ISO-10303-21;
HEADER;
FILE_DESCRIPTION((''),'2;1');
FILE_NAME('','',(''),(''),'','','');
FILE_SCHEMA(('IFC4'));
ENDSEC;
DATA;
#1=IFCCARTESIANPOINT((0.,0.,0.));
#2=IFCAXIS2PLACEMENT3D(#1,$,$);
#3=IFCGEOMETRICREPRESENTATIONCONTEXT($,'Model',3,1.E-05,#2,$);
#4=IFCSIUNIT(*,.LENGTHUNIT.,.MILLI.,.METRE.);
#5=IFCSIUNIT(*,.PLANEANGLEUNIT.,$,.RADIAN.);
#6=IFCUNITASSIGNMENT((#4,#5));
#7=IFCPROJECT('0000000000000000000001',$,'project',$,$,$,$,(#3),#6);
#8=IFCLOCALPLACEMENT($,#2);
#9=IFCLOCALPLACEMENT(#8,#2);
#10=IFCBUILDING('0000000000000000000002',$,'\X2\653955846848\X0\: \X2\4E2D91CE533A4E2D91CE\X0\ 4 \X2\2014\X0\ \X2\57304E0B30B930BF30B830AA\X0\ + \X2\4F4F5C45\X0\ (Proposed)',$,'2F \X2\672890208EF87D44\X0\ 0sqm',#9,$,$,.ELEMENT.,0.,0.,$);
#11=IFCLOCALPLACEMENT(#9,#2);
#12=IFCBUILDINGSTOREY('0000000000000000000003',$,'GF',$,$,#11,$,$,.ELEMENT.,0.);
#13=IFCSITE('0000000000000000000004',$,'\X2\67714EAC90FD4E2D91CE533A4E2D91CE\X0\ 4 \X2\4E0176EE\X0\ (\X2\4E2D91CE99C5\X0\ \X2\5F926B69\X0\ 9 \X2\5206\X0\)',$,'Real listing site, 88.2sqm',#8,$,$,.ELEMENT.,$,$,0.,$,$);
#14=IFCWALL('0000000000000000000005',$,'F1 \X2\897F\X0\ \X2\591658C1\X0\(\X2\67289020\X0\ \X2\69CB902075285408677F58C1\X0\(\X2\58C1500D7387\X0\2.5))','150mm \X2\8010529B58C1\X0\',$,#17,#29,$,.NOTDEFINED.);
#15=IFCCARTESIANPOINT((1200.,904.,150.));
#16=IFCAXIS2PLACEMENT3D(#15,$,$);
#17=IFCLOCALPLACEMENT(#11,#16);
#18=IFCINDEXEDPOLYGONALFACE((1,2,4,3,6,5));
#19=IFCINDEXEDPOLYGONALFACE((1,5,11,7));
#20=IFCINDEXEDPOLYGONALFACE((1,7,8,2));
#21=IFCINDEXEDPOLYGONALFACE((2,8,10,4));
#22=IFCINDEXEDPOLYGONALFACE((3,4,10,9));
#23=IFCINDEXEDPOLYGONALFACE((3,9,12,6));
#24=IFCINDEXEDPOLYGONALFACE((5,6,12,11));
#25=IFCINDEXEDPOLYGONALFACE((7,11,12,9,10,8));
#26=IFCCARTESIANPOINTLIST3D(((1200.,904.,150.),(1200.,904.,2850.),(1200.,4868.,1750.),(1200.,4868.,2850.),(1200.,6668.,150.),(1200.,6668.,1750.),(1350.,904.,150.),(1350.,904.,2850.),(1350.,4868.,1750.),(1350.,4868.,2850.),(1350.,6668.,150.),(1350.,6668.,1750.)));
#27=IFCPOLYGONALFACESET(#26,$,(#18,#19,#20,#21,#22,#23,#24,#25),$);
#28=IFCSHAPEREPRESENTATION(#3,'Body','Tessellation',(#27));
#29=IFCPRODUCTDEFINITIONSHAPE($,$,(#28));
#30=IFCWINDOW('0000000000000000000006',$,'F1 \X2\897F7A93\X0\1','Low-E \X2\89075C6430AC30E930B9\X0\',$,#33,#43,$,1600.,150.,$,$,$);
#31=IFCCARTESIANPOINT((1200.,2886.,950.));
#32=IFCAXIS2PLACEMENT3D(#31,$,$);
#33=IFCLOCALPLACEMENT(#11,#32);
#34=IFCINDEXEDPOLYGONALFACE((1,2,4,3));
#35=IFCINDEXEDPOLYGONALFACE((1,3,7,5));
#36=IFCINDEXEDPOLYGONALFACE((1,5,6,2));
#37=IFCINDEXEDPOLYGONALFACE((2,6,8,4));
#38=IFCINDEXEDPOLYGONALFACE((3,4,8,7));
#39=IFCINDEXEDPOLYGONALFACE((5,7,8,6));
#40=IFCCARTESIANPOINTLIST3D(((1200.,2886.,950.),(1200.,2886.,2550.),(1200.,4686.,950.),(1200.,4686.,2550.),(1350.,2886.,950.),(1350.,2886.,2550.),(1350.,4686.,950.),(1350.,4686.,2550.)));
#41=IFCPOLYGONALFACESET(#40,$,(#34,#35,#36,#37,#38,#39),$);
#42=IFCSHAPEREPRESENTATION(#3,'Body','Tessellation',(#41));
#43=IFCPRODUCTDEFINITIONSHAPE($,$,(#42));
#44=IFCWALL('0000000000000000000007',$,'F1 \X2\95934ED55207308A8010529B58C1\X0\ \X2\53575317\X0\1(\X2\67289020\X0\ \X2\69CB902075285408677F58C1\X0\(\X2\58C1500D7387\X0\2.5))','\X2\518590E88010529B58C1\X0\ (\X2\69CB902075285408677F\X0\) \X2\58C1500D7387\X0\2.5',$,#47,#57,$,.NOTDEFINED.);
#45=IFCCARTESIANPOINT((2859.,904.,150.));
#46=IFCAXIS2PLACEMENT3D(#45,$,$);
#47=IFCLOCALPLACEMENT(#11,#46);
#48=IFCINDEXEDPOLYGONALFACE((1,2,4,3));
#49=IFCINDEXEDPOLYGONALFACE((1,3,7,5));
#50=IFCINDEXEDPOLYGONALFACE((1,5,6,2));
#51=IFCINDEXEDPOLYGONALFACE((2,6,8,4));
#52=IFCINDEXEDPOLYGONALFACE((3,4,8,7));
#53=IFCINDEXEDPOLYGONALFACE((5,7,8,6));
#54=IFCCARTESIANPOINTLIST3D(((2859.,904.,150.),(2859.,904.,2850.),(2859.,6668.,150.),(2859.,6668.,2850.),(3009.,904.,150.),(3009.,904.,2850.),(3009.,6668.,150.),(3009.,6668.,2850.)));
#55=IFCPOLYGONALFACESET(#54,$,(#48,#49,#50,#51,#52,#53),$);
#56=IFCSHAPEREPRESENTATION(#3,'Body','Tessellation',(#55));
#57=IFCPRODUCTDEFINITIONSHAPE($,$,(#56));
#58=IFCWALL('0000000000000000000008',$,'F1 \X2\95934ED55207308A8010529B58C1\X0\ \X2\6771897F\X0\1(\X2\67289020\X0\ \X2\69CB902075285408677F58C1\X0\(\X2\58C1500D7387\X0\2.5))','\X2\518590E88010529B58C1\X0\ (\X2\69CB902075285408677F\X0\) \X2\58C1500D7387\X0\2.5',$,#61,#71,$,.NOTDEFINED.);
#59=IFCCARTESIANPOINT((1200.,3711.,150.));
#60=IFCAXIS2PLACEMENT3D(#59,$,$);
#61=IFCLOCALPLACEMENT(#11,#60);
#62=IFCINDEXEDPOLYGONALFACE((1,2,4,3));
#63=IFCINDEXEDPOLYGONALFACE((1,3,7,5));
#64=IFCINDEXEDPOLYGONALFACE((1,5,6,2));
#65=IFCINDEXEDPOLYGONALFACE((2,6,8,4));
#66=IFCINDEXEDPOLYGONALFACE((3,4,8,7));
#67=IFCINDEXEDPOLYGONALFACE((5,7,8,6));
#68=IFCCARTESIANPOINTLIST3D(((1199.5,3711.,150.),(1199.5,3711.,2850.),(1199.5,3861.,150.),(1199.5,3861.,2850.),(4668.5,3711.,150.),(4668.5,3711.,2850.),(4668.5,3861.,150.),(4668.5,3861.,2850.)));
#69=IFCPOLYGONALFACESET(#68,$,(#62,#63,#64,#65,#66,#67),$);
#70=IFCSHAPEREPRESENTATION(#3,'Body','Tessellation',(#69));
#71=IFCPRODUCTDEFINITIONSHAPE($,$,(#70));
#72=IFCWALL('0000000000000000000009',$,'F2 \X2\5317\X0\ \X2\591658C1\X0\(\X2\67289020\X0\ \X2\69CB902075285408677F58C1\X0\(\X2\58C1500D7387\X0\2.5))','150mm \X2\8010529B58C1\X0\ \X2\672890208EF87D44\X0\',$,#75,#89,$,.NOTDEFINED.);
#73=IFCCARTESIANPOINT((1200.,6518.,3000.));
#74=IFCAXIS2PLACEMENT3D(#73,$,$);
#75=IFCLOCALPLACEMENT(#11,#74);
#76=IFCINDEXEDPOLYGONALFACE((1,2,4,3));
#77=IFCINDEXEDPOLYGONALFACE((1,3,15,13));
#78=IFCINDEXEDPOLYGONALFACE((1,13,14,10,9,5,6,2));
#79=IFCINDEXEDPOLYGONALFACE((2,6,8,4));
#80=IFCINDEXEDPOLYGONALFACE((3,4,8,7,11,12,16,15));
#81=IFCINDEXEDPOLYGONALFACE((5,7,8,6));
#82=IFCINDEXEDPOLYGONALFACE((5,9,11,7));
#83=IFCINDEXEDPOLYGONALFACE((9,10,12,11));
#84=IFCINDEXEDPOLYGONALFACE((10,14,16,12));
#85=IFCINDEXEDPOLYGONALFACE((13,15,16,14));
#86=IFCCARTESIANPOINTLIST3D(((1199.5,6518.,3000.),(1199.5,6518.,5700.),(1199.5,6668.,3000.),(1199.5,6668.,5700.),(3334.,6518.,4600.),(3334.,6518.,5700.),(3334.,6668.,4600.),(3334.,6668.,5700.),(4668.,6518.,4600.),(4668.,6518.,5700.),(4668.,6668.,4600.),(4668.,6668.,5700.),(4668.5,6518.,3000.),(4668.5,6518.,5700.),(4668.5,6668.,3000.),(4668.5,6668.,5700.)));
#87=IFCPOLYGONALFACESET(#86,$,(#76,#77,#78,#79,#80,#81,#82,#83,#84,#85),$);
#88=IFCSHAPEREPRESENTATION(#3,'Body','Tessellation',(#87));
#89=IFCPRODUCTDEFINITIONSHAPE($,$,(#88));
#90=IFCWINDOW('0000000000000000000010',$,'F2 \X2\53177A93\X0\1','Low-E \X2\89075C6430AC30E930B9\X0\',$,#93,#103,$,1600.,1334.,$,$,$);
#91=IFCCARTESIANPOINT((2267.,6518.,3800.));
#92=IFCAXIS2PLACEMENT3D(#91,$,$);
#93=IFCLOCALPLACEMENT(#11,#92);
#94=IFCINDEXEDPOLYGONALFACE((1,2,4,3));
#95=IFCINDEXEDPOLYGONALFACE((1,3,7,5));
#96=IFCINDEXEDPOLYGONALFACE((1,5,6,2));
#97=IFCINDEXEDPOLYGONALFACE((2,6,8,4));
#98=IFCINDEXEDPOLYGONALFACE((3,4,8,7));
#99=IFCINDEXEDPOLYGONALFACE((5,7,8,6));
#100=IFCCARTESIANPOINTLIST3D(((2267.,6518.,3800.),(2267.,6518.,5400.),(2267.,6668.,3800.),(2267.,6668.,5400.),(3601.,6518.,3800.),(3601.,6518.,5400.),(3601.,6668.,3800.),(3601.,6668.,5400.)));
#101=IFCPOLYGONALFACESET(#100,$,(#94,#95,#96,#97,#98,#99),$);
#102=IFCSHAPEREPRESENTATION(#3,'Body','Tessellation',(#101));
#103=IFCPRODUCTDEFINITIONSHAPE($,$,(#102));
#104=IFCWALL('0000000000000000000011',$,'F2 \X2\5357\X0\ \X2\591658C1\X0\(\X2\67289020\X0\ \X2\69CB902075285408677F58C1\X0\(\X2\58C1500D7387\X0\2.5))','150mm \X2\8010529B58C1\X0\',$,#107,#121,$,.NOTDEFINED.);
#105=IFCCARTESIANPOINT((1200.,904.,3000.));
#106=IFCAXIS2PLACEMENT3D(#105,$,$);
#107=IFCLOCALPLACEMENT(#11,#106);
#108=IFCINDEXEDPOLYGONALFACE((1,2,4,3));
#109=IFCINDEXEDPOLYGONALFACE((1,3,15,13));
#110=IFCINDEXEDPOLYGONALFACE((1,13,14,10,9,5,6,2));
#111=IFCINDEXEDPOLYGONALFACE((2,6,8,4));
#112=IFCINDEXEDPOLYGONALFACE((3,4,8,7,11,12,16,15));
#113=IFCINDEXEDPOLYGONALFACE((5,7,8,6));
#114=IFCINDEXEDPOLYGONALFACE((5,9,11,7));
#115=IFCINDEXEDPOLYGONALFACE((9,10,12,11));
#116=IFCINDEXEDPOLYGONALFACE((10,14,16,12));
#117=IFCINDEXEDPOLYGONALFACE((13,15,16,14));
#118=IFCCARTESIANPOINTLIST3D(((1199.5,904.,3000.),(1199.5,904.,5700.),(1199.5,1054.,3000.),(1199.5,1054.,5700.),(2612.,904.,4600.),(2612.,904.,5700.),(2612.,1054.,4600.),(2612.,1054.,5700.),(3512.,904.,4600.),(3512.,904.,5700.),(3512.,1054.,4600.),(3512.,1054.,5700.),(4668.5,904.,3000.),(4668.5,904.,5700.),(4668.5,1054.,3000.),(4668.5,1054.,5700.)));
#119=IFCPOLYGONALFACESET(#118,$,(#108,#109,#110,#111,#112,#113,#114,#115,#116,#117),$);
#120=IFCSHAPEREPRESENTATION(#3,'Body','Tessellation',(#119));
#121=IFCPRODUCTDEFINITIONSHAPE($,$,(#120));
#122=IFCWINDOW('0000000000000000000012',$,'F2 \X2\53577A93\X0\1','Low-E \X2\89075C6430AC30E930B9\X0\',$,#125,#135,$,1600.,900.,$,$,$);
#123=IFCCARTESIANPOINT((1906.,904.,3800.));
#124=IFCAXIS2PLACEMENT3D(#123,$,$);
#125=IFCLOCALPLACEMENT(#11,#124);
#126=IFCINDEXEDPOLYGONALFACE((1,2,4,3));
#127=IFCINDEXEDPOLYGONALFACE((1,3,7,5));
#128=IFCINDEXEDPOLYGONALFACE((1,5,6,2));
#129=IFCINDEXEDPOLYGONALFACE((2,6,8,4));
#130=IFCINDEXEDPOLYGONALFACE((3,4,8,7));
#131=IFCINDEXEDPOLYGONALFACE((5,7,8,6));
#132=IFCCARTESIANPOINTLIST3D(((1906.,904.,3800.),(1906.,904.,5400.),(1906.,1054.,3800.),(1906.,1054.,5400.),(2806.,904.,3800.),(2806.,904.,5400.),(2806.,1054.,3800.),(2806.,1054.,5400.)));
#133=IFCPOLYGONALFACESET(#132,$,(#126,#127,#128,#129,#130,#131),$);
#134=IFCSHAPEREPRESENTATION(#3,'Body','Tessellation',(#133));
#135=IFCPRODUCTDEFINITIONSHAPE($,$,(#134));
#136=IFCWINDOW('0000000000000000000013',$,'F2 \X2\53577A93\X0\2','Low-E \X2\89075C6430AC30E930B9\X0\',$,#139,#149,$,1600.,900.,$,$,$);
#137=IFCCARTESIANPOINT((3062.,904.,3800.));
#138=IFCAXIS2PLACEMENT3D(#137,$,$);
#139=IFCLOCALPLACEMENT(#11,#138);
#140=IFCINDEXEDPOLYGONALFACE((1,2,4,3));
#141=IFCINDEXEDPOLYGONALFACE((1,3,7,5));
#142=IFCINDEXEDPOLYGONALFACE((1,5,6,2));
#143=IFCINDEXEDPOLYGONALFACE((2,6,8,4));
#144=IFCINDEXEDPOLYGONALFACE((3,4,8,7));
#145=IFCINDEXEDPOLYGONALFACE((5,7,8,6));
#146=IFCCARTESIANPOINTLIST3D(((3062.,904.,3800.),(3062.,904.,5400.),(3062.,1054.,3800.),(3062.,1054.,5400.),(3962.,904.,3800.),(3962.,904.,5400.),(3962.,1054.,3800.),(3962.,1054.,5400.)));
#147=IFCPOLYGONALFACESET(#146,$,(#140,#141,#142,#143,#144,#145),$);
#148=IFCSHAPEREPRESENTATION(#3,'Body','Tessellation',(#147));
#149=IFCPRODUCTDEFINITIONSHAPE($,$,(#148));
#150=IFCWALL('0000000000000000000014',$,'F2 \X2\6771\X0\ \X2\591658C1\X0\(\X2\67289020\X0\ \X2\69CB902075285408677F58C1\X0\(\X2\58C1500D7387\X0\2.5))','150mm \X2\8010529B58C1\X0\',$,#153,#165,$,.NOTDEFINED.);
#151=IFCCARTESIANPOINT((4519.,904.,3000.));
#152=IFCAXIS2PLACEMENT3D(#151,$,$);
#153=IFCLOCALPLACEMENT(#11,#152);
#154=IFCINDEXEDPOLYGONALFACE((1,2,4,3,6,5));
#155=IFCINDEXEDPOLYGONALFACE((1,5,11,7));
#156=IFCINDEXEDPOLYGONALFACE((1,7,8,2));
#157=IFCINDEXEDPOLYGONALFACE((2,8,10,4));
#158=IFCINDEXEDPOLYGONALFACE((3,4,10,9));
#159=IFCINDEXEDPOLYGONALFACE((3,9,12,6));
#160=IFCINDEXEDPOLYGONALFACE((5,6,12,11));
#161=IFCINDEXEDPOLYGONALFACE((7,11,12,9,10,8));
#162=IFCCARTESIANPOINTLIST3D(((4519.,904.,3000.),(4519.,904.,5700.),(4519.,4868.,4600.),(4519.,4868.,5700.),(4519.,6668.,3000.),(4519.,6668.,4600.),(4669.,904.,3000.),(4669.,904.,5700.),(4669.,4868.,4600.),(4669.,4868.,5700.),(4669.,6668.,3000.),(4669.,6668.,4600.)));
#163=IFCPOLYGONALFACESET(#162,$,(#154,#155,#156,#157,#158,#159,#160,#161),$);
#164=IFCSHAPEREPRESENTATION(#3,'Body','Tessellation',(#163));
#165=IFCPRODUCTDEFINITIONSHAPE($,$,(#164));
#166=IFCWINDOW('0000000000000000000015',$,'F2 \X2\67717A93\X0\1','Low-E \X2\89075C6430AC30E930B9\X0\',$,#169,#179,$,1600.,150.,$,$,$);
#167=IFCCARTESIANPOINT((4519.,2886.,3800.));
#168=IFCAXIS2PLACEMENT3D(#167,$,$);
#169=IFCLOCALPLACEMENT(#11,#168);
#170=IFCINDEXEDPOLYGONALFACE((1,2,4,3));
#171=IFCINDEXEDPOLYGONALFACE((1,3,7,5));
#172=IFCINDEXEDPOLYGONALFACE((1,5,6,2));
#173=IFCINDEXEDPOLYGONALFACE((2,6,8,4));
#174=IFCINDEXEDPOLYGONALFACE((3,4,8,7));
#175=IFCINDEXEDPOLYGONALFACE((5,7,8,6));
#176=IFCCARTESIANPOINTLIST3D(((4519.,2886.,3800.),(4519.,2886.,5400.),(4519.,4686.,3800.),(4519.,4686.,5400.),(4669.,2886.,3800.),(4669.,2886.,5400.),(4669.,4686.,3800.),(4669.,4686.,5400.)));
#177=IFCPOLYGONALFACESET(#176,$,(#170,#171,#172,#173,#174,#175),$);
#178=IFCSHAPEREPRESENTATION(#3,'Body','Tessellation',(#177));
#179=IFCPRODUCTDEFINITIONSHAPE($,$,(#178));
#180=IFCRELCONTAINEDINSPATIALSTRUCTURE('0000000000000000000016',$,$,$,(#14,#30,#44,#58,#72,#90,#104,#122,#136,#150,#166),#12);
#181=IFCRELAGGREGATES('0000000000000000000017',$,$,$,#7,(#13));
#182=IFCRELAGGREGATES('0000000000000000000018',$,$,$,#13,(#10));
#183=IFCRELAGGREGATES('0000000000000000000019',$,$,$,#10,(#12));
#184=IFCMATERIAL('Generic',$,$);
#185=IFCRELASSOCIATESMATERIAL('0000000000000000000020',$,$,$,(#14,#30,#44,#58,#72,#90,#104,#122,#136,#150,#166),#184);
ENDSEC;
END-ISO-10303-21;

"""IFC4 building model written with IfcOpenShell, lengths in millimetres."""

from ifc_helpers import new_model, si_unit, frame, frame_2d, origin, place, context, project, spatial, rectangle, extrude, material, element, fill, save


model = new_model("IFC4")

# Units and contexts
model_context = context("Model", 3, precision=1e-05, world=origin())
ifc_project = project(units=[si_unit("LENGTHUNIT", "METRE", prefix="MILLI"), si_unit("PLANEANGLEUNIT", "RADIAN")], contexts=[model_context])

# Site, building, storey
site_placement = place(None, origin())
site = spatial("IfcSite", under=ifc_project, at=site_placement, Name="東京都中野区中野 4 丁目 (中野駅 徒歩 9 分)", ObjectType="Real listing site, 88.2sqm", CompositionType="ELEMENT", RefElevation=0.0)
building_placement = place(site_placement, origin())
building = spatial("IfcBuilding", under=site, at=building_placement, Name="改善案: 中野区中野 4 — 地下スタジオ + 住居 (Proposed)", ObjectType="2F 木造軸組 0sqm", CompositionType="ELEMENT", ElevationOfRefHeight=0.0, ElevationOfTerrain=0.0)
storey_placement = place(building_placement, origin())
storey = spatial("IfcBuildingStorey", under=building, at=storey_placement, Name="GF", CompositionType="ELEMENT", Elevation=0.0)

# Shared definitions
ifc_material_1 = material(Name="Generic")

# Wall, opening, window
wall_1_placement = place(storey_placement, frame((1200.0, 904.0, 150.0)))
wall_1 = element("IfcWall", 1, at=wall_1_placement, inside=storey, material=ifc_material_1, Name="F1 西 外壁(木造 構造用合板壁(壁倍率2.5))", Description="150mm 耐力壁", PredefinedType="NOTDEFINED", context=model_context, shape_type="SweptSolid", body=[
    extrude(rectangle(XDim=150.0, YDim=5764.0, at=frame_2d((75.0, 2882.0))), frame((1200.0, 904.0, 150.0)), (0.0, 0.0, 1.0), 2700.0),
])
opening_1_placement = place(storey_placement, frame((1200.0, 2886.0, 950.0)))
opening_1 = element("IfcOpeningElement", 2, at=opening_1_placement, cuts=wall_1, PredefinedType="NOTDEFINED", context=model_context, shape_type="SweptSolid", body=[
    extrude(rectangle(XDim=150.0, YDim=1800.0, at=frame_2d((75.0, 900.0))), frame((1200.0, 2886.0, 950.0)), (0.0, 0.0, 1.0), 1600.0),
])
window_1_placement = place(storey_placement, frame((1200.0, 2886.0, 950.0)))
window_1 = element("IfcWindow", 3, at=window_1_placement, inside=storey, material=ifc_material_1, Name="F1 西窓1", Description="Low-E 複層ガラス", OverallHeight=1600.0, OverallWidth=150.0, context=model_context, shape_type="SweptSolid", body=[
    extrude(rectangle(XDim=150.0, YDim=1800.0, at=frame_2d((75.0, 900.0))), frame((1200.0, 2886.0, 950.0)), (0.0, 0.0, 1.0), 1600.0),
])
fill(opening_1, window_1)

# Walls
wall_2_placement = place(storey_placement, frame((2859.0, 904.0, 150.0)))
element("IfcWall", 4, at=wall_2_placement, inside=storey, material=ifc_material_1, Name="F1 間仕切り耐力壁 南北1(木造 構造用合板壁(壁倍率2.5))", Description="内部耐力壁 (構造用合板) 壁倍率2.5", PredefinedType="NOTDEFINED", context=model_context, shape_type="SweptSolid", body=[
    extrude(rectangle(XDim=150.0, YDim=5764.0, at=frame_2d((75.0, 2882.0))), frame((2859.0, 904.0, 150.0)), (0.0, 0.0, 1.0), 2700.0),
])
wall_3_placement = place(storey_placement, frame((1200.0, 3711.0, 150.0)))
element("IfcWall", 5, at=wall_3_placement, inside=storey, material=ifc_material_1, Name="F1 間仕切り耐力壁 東西1(木造 構造用合板壁(壁倍率2.5))", Description="内部耐力壁 (構造用合板) 壁倍率2.5", PredefinedType="NOTDEFINED", context=model_context, shape_type="SweptSolid", body=[
    extrude(rectangle(XDim=3469.0, YDim=150.0, at=frame_2d((1734.0, 75.0))), frame((1200.0, 3711.0, 150.0)), (0.0, 0.0, 1.0), 2700.0),
])

# Wall, opening, window
wall_4_placement = place(storey_placement, frame((1200.0, 6518.0, 3000.0)))
wall_4 = element("IfcWall", 6, at=wall_4_placement, inside=storey, material=ifc_material_1, Name="F2 北 外壁(木造 構造用合板壁(壁倍率2.5))", Description="150mm 耐力壁 木造軸組", PredefinedType="NOTDEFINED", context=model_context, shape_type="SweptSolid", body=[
    extrude(rectangle(XDim=3469.0, YDim=150.0, at=frame_2d((1734.0, 75.0))), frame((1200.0, 6518.0, 3000.0)), (0.0, 0.0, 1.0), 2700.0),
])
opening_2_placement = place(storey_placement, frame((2267.0, 6518.0, 3800.0)))
opening_2 = element("IfcOpeningElement", 7, at=opening_2_placement, cuts=wall_4, PredefinedType="NOTDEFINED", context=model_context, shape_type="SweptSolid", body=[
    extrude(rectangle(XDim=1334.0, YDim=150.0, at=frame_2d((667.0, 75.0))), frame((2267.0, 6518.0, 3800.0)), (0.0, 0.0, 1.0), 1600.0),
])
window_2_placement = place(storey_placement, frame((2267.0, 6518.0, 3800.0)))
window_2 = element("IfcWindow", 8, at=window_2_placement, inside=storey, material=ifc_material_1, Name="F2 北窓1", Description="Low-E 複層ガラス", OverallHeight=1600.0, OverallWidth=1334.0, context=model_context, shape_type="SweptSolid", body=[
    extrude(rectangle(XDim=1334.0, YDim=150.0, at=frame_2d((667.0, 75.0))), frame((2267.0, 6518.0, 3800.0)), (0.0, 0.0, 1.0), 1600.0),
])
fill(opening_2, window_2)

# Wall, openings, windows
wall_5_placement = place(storey_placement, frame((1200.0, 904.0, 3000.0)))
wall_5 = element("IfcWall", 9, at=wall_5_placement, inside=storey, material=ifc_material_1, Name="F2 南 外壁(木造 構造用合板壁(壁倍率2.5))", Description="150mm 耐力壁", PredefinedType="NOTDEFINED", context=model_context, shape_type="SweptSolid", body=[
    extrude(rectangle(XDim=3469.0, YDim=150.0, at=frame_2d((1734.0, 75.0))), frame((1200.0, 904.0, 3000.0)), (0.0, 0.0, 1.0), 2700.0),
])
opening_3_placement = place(storey_placement, frame((1906.0, 904.0, 3800.0)))
opening_3 = element("IfcOpeningElement", 10, at=opening_3_placement, cuts=wall_5, PredefinedType="NOTDEFINED", context=model_context, shape_type="SweptSolid", body=[
    extrude(rectangle(XDim=900.0, YDim=150.0, at=frame_2d((450.0, 75.0))), frame((1906.0, 904.0, 3800.0)), (0.0, 0.0, 1.0), 1600.0),
])
opening_4_placement = place(storey_placement, frame((3062.0, 904.0, 3800.0)))
opening_4 = element("IfcOpeningElement", 11, at=opening_4_placement, cuts=wall_5, PredefinedType="NOTDEFINED", context=model_context, shape_type="SweptSolid", body=[
    extrude(rectangle(XDim=900.0, YDim=150.0, at=frame_2d((450.0, 75.0))), frame((3062.0, 904.0, 3800.0)), (0.0, 0.0, 1.0), 1600.0),
])
window_3_placement = place(storey_placement, frame((1906.0, 904.0, 3800.0)))
window_3 = element("IfcWindow", 12, at=window_3_placement, inside=storey, material=ifc_material_1, Name="F2 南窓1", Description="Low-E 複層ガラス", OverallHeight=1600.0, OverallWidth=900.0, context=model_context, shape_type="SweptSolid", body=[
    extrude(rectangle(XDim=900.0, YDim=150.0, at=frame_2d((450.0, 75.0))), frame((1906.0, 904.0, 3800.0)), (0.0, 0.0, 1.0), 1600.0),
])
fill(opening_3, window_3)
window_4_placement = place(storey_placement, frame((3062.0, 904.0, 3800.0)))
window_4 = element("IfcWindow", 13, at=window_4_placement, inside=storey, material=ifc_material_1, Name="F2 南窓2", Description="Low-E 複層ガラス", OverallHeight=1600.0, OverallWidth=900.0, context=model_context, shape_type="SweptSolid", body=[
    extrude(rectangle(XDim=900.0, YDim=150.0, at=frame_2d((450.0, 75.0))), frame((3062.0, 904.0, 3800.0)), (0.0, 0.0, 1.0), 1600.0),
])
fill(opening_4, window_4)

# Wall, opening, window
wall_6_placement = place(storey_placement, frame((4519.0, 904.0, 3000.0)))
wall_6 = element("IfcWall", 14, at=wall_6_placement, inside=storey, material=ifc_material_1, Name="F2 東 外壁(木造 構造用合板壁(壁倍率2.5))", Description="150mm 耐力壁", PredefinedType="NOTDEFINED", context=model_context, shape_type="SweptSolid", body=[
    extrude(rectangle(XDim=150.0, YDim=5764.0, at=frame_2d((75.0, 2882.0))), frame((4519.0, 904.0, 3000.0)), (0.0, 0.0, 1.0), 2700.0),
])
opening_5_placement = place(storey_placement, frame((4519.0, 2886.0, 3800.0)))
opening_5 = element("IfcOpeningElement", 15, at=opening_5_placement, cuts=wall_6, PredefinedType="NOTDEFINED", context=model_context, shape_type="SweptSolid", body=[
    extrude(rectangle(XDim=150.0, YDim=1800.0, at=frame_2d((75.0, 900.0))), frame((4519.0, 2886.0, 3800.0)), (0.0, 0.0, 1.0), 1600.0),
])
window_5_placement = place(storey_placement, frame((4519.0, 2886.0, 3800.0)))
window_5 = element("IfcWindow", 16, at=window_5_placement, inside=storey, material=ifc_material_1, Name="F2 東窓1", Description="Low-E 複層ガラス", OverallHeight=1600.0, OverallWidth=150.0, context=model_context, shape_type="SweptSolid", body=[
    extrude(rectangle(XDim=150.0, YDim=1800.0, at=frame_2d((75.0, 900.0))), frame((4519.0, 2886.0, 3800.0)), (0.0, 0.0, 1.0), 1600.0),
])
fill(opening_5, window_5)

save(model, "model.ifc")
